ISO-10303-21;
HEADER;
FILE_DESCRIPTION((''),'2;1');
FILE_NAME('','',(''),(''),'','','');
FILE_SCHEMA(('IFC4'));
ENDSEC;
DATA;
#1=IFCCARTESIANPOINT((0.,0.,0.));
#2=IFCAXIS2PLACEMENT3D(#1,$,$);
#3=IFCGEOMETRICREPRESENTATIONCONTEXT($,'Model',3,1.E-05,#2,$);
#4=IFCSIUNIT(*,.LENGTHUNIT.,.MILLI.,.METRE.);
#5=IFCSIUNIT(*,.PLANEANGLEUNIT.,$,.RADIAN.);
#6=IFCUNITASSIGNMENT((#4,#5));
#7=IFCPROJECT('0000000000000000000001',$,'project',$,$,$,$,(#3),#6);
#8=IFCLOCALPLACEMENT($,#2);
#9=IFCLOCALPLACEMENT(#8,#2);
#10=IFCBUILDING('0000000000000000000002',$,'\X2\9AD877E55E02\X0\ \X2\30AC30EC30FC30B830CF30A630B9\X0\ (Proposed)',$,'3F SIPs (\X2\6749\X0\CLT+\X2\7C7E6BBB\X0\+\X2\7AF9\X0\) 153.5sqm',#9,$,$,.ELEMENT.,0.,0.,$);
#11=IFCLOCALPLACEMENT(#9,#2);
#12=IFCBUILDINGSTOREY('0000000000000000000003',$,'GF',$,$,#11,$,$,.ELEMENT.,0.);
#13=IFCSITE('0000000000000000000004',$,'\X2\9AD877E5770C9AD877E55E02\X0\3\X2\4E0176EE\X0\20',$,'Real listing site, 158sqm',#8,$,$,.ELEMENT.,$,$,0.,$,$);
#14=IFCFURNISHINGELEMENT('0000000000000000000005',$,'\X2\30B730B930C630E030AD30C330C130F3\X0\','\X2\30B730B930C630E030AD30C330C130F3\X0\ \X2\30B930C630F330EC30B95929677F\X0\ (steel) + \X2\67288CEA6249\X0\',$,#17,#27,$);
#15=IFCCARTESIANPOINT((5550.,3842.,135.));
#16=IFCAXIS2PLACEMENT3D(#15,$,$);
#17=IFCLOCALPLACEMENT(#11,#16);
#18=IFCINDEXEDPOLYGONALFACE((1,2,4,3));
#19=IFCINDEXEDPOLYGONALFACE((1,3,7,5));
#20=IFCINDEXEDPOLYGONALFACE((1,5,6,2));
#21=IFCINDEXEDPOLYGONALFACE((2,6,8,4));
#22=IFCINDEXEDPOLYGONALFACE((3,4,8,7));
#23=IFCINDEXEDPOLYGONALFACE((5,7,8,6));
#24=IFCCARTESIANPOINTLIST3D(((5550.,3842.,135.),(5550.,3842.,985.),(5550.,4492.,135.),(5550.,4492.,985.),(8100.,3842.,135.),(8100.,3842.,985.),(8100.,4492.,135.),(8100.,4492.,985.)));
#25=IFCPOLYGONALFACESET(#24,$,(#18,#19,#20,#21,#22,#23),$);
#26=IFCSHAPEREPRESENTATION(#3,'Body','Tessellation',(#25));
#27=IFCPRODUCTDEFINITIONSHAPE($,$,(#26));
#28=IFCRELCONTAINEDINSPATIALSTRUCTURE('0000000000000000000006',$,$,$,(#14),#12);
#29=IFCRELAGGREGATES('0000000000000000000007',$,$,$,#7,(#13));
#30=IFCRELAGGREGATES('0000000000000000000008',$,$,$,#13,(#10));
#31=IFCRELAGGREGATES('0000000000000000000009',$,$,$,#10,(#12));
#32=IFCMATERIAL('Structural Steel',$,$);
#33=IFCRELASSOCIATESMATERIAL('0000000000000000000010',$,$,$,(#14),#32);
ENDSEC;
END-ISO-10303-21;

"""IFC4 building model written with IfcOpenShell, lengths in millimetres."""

from ifc_helpers import new_model, si_unit, frame, frame_2d, origin, place, context, project, spatial, rectangle, extrude, material, element, save


model = new_model("IFC4")

# Units and contexts
model_context = context("Model", 3, precision=1e-05, world=origin())
ifc_project = project(units=[si_unit("LENGTHUNIT", "METRE", prefix="MILLI"), si_unit("PLANEANGLEUNIT", "RADIAN")], contexts=[model_context])

# Site, building, storey
site_placement = place(None, origin())
site = spatial("IfcSite", under=ifc_project, at=site_placement, Name="高知県高知市3丁目20", ObjectType="Real listing site, 158sqm", CompositionType="ELEMENT", RefElevation=0.0)
building_placement = place(site_placement, origin())
building = spatial("IfcBuilding", under=site, at=building_placement, Name="高知市 ガレージハウス (Proposed)", ObjectType="3F SIPs (杉CLT+籾殻+竹) 153.5sqm", CompositionType="ELEMENT", ElevationOfRefHeight=0.0, ElevationOfTerrain=0.0)
storey_placement = place(building_placement, origin())
storey = spatial("IfcBuildingStorey", under=building, at=storey_placement, Name="GF", CompositionType="ELEMENT", Elevation=0.0)

# Furnishing element
ifc_material_1 = material(Name="Structural Steel")
furnishing_1_placement = place(storey_placement, frame((5550.0, 3842.0, 135.0)))
element("IfcFurnishingElement", 1, at=furnishing_1_placement, inside=storey, material=ifc_material_1, Name="システムキッチン", Description="システムキッチン ステンレス天板 (steel) + 木質扉", context=model_context, shape_type="SweptSolid", body=[
    extrude(rectangle(XDim=2550.0, YDim=650.0, at=frame_2d((1275.0, 325.0))), frame((5550.0, 3842.0, 135.0)), (0.0, 0.0, 1.0), 850.0),
])

save(model, "model.ifc")
